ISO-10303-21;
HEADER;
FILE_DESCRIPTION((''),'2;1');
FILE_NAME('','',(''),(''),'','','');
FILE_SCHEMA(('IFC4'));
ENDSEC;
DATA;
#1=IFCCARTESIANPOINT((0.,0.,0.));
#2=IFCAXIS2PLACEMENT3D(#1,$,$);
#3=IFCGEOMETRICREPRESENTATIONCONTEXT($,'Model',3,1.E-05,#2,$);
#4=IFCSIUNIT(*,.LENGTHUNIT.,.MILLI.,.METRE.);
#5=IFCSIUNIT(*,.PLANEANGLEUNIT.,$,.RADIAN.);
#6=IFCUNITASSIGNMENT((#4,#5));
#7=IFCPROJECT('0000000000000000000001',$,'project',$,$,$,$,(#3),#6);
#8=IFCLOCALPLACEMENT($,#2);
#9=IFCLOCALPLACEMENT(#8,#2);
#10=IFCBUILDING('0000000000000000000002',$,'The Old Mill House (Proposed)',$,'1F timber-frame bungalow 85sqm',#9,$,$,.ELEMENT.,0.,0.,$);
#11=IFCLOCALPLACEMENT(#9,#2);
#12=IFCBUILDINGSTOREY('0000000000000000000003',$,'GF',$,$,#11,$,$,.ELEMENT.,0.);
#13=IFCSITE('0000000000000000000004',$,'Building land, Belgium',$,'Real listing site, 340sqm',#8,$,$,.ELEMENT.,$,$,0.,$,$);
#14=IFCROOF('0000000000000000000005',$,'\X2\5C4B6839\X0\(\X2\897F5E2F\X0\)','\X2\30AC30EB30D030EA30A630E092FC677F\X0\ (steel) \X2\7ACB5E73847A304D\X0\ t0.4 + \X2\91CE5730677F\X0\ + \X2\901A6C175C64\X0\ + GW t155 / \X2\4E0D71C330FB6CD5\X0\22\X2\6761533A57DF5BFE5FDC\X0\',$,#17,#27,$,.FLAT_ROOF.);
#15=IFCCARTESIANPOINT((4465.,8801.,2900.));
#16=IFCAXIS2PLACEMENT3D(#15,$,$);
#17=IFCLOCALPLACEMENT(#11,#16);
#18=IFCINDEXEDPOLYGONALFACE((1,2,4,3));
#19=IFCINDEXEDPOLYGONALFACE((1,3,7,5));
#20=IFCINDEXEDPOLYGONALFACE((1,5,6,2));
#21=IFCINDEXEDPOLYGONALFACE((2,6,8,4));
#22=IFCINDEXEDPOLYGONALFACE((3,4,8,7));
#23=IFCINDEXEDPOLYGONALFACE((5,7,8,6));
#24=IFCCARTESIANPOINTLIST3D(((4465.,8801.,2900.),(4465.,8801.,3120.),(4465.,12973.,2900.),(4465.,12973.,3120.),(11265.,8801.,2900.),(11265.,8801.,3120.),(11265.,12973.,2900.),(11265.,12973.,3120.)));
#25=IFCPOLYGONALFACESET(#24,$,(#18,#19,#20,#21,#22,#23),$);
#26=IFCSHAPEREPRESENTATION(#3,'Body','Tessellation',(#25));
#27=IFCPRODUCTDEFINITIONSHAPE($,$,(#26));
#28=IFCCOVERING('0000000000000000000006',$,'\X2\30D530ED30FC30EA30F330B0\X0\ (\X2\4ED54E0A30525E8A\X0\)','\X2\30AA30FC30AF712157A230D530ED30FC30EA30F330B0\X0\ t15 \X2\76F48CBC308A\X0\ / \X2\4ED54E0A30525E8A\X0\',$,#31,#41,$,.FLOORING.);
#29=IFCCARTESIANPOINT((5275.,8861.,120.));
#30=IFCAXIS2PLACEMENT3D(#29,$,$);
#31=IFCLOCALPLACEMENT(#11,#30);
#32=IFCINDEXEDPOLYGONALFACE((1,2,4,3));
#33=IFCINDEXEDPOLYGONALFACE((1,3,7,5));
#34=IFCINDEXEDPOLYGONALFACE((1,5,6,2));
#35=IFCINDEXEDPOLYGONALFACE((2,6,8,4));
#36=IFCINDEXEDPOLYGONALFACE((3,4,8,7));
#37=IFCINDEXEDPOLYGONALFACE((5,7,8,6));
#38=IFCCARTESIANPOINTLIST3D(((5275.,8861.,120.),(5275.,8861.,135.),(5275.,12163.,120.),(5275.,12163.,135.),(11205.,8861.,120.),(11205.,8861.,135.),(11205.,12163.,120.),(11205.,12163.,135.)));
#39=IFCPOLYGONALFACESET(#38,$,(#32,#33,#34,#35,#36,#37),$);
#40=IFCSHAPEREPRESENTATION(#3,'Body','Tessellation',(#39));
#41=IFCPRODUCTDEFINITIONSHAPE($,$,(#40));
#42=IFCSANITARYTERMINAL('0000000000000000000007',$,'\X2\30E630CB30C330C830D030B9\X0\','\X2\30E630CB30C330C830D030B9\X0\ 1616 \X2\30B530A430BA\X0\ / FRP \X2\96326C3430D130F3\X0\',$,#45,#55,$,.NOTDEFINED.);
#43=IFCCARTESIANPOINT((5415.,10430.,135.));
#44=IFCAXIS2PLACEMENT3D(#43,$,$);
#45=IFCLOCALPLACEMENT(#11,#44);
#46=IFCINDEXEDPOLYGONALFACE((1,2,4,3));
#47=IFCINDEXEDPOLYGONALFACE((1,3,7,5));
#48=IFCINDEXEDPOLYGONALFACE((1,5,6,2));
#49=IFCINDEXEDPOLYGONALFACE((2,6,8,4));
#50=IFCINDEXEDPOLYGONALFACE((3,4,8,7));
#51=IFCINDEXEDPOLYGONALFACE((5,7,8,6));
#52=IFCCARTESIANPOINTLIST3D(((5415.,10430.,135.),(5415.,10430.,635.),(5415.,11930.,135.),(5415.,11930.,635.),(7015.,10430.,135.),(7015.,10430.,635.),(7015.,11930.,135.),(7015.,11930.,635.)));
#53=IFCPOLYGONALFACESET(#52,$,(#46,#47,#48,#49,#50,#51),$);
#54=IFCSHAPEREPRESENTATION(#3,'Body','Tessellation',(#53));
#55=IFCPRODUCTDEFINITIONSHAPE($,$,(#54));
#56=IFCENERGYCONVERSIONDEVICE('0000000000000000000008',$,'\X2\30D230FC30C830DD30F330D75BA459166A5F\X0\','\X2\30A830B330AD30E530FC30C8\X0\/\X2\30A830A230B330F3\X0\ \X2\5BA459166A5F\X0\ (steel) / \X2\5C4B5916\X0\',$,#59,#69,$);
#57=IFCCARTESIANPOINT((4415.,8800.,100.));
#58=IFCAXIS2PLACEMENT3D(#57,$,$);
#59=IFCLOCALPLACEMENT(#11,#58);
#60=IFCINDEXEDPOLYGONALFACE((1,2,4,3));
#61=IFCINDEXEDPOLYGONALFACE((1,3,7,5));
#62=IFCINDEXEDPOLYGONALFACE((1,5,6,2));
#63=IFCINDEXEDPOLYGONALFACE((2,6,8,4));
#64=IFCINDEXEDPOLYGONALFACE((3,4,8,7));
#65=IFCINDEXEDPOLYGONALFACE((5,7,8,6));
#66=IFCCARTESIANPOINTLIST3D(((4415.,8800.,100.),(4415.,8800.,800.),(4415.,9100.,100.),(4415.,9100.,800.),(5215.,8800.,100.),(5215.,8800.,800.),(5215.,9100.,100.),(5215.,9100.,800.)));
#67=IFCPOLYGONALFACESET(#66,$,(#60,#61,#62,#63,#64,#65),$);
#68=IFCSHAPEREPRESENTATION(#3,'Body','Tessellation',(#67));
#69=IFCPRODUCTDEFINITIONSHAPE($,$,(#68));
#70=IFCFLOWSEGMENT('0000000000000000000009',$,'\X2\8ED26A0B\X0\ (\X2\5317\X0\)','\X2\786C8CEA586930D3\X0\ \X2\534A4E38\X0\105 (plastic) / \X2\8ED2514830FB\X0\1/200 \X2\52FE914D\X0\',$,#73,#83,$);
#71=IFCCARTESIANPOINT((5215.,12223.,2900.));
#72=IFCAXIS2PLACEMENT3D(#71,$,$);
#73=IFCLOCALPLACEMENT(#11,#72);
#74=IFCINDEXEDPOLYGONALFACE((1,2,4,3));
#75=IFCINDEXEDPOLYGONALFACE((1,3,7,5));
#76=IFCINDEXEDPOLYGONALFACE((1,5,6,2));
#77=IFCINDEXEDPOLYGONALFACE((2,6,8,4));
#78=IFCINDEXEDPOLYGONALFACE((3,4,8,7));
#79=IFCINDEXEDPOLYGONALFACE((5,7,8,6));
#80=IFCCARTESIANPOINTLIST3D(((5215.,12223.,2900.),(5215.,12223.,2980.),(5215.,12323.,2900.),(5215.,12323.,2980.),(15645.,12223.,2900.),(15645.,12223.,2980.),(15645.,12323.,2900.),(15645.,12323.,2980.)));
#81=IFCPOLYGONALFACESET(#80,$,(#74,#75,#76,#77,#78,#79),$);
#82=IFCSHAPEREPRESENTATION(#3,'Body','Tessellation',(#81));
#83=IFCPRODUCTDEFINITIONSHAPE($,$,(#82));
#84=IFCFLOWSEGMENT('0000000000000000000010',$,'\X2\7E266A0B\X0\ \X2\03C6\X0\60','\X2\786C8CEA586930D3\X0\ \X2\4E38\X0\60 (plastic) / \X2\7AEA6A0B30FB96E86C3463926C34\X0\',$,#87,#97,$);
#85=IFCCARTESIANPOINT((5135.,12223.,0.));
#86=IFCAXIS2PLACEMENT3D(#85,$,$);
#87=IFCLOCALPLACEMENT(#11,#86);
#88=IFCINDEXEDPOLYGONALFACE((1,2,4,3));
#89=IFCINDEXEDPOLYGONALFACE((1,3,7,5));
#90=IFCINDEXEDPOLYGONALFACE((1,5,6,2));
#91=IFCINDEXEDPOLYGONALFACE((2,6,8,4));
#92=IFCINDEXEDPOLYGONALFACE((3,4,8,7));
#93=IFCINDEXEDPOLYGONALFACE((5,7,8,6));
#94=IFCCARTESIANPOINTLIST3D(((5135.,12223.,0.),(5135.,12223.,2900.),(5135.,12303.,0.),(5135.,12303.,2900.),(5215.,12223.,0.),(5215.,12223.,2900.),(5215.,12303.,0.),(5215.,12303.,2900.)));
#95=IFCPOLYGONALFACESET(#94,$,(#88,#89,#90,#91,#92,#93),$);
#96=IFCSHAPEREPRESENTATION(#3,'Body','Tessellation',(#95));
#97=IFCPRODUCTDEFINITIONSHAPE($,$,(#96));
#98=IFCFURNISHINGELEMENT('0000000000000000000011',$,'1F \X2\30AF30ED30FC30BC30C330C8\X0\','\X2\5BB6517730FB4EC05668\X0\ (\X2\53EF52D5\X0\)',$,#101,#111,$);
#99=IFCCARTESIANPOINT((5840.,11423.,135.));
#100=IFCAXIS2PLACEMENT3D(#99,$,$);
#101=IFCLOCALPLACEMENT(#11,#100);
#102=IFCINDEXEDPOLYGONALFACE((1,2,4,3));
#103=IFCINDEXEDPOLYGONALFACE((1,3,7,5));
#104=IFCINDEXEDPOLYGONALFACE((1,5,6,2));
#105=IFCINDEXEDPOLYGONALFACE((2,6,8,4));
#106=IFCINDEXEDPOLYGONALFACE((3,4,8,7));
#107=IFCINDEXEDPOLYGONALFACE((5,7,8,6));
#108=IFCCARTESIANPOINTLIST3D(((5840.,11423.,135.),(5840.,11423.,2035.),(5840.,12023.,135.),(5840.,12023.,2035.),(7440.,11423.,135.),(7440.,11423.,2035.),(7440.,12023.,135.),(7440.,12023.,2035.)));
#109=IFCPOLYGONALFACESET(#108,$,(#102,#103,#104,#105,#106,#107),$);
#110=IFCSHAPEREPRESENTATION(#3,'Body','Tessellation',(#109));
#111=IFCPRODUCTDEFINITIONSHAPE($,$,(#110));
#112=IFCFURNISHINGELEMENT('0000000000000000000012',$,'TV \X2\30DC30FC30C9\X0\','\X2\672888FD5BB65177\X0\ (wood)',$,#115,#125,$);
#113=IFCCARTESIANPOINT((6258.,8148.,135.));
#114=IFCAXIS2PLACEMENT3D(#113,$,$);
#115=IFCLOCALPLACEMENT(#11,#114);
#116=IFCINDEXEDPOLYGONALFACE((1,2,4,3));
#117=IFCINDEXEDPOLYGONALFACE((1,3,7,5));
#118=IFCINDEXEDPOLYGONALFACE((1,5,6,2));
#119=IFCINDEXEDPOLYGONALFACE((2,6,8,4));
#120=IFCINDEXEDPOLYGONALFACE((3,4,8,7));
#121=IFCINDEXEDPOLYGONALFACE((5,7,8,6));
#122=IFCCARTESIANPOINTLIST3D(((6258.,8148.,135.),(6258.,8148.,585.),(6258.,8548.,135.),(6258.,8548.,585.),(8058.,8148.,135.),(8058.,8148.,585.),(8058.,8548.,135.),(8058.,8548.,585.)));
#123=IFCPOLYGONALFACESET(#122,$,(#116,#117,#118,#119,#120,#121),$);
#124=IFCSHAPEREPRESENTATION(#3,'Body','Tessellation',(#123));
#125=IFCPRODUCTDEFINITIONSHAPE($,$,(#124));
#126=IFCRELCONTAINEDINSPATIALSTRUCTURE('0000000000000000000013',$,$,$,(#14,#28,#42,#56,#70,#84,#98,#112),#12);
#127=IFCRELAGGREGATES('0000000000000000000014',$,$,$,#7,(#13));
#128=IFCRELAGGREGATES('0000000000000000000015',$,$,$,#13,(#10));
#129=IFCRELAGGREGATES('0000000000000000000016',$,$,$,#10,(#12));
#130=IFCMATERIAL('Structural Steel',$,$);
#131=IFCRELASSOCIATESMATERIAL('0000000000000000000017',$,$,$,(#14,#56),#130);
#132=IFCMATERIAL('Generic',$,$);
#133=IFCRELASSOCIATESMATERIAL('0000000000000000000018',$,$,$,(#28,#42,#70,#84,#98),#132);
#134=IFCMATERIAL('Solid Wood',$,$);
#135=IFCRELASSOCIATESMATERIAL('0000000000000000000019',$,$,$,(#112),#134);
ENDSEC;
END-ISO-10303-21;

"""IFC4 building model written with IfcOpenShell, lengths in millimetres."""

from ifc_helpers import new_model, si_unit, frame, frame_2d, origin, place, context, project, spatial, rectangle, extrude, material, element, save


model = new_model("IFC4")

# Units and contexts
model_context = context("Model", 3, precision=1e-05, world=origin())
ifc_project = project(units=[si_unit("LENGTHUNIT", "METRE", prefix="MILLI"), si_unit("PLANEANGLEUNIT", "RADIAN")], contexts=[model_context])

# Site, building, storey
site_placement = place(None, origin())
site = spatial("IfcSite", under=ifc_project, at=site_placement, Name="Building land, Belgium", ObjectType="Real listing site, 340sqm", CompositionType="ELEMENT", RefElevation=0.0)
building_placement = place(site_placement, origin())
building = spatial("IfcBuilding", under=site, at=building_placement, Name="The Old Mill House (Proposed)", ObjectType="1F timber-frame bungalow 85sqm", CompositionType="ELEMENT", ElevationOfRefHeight=0.0, ElevationOfTerrain=0.0)
storey_placement = place(building_placement, origin())
storey = spatial("IfcBuildingStorey", under=building, at=storey_placement, Name="GF", CompositionType="ELEMENT", Elevation=0.0)

# Shared definitions
ifc_material_1 = material(Name="Solid Wood")

# Roof
ifc_material_2 = material(Name="Structural Steel")
roof_placement = place(storey_placement, frame((4465.0, 8801.0, 2900.0)))
element("IfcRoof", 1, at=roof_placement, inside=storey, material=ifc_material_2, Name="屋根(西帯)", Description="ガルバリウム鋼板 (steel) 立平葺き t0.4 + 野地板 + 通気層 + GW t155 / 不燃・法22条区域対応", PredefinedType="FLAT_ROOF", context=model_context, shape_type="SweptSolid", body=[
    extrude(rectangle(XDim=6800.0, YDim=4172.0, at=frame_2d((3400.0, 2086.0))), frame((4465.0, 8801.0, 2900.0)), (0.0, 0.0, 1.0), 220.0),
])

# Covering
ifc_material_3 = material(Name="Generic")
covering_placement = place(storey_placement, frame((5275.0, 8861.0, 120.0)))
element("IfcCovering", 2, at=covering_placement, inside=storey, material=ifc_material_3, Name="フローリング (仕上げ床)", Description="オーク無垢フローリング t15 直貼り / 仕上げ床", PredefinedType="FLOORING", context=model_context, shape_type="SweptSolid", body=[
    extrude(rectangle(XDim=5930.0, YDim=3302.0, at=frame_2d((2965.0, 1651.0))), frame((5275.0, 8861.0, 120.0)), (0.0, 0.0, 1.0), 15.0),
])

# Sanitary terminal
sanitary_terminal_placement = place(storey_placement, frame((5415.0, 10430.0, 135.0)))
element("IfcSanitaryTerminal", 3, at=sanitary_terminal_placement, inside=storey, material=ifc_material_3, Name="ユニットバス", Description="ユニットバス 1616 サイズ / FRP 防水パン", PredefinedType="NOTDEFINED", context=model_context, shape_type="SweptSolid", body=[
    extrude(rectangle(XDim=1600.0, YDim=1500.0, at=frame_2d((800.0, 750.0))), frame((5415.0, 10430.0, 135.0)), (0.0, 0.0, 1.0), 500.0),
])

# Energy conversion device
energy_conversion_device_placement = place(storey_placement, frame((4415.0, 8800.0, 100.0)))
element("IfcEnergyConversionDevice", 4, at=energy_conversion_device_placement, inside=storey, material=ifc_material_2, Name="ヒートポンプ室外機", Description="エコキュート/エアコン 室外機 (steel) / 屋外", context=model_context, shape_type="SweptSolid", body=[
    extrude(rectangle(XDim=800.0, YDim=300.0, at=frame_2d((400.0, 150.0))), frame((4415.0, 8800.0, 100.0)), (0.0, 0.0, 1.0), 700.0),
])

# Flow segments
flow_segment_1_placement = place(storey_placement, frame((5215.0, 12223.0, 2900.0)))
element("IfcFlowSegment", 5, at=flow_segment_1_placement, inside=storey, material=ifc_material_3, Name="軒樋 (北)", Description="硬質塩ビ 半丸105 (plastic) / 軒先・1/200 勾配", context=model_context, shape_type="SweptSolid", body=[
    extrude(rectangle(XDim=10430.0, YDim=100.0, at=frame_2d((5215.0, 50.0))), frame((5215.0, 12223.0, 2900.0)), (0.0, 0.0, 1.0), 80.0),
])
flow_segment_2_placement = place(storey_placement, frame((5135.0, 12223.0, 0.0)))
element("IfcFlowSegment", 6, at=flow_segment_2_placement, inside=storey, material=ifc_material_3, Name="縦樋 φ60", Description="硬質塩ビ 丸60 (plastic) / 竪樋・雨水排水", context=model_context, shape_type="SweptSolid", body=[
    extrude(rectangle(XDim=80.0, YDim=80.0, at=frame_2d((40.0, 40.0))), frame((5135.0, 12223.0, 0.0)), (0.0, 0.0, 1.0), 2900.0),
])

# Furnishing elements
furnishing_1_placement = place(storey_placement, frame((5840.0, 11423.0, 135.0)))
element("IfcFurnishingElement", 7, at=furnishing_1_placement, inside=storey, material=ifc_material_3, Name="1F クローゼット", Description="家具・什器 (可動)", context=model_context, shape_type="SweptSolid", body=[
    extrude(rectangle(XDim=1600.0, YDim=600.0, at=frame_2d((800.0, 300.0))), frame((5840.0, 11423.0, 135.0)), (0.0, 0.0, 1.0), 1900.0),
])
furnishing_2_placement = place(storey_placement, frame((6258.0, 8148.0, 135.0)))
element("IfcFurnishingElement", 8, at=furnishing_2_placement, inside=storey, material=ifc_material_1, Name="TV ボード", Description="木製家具 (wood)", context=model_context, shape_type="SweptSolid", body=[
    extrude(rectangle(XDim=1800.0, YDim=400.0, at=frame_2d((900.0, 200.0))), frame((6258.0, 8148.0, 135.0)), (0.0, 0.0, 1.0), 450.0),
])

save(model, "model.ifc")
